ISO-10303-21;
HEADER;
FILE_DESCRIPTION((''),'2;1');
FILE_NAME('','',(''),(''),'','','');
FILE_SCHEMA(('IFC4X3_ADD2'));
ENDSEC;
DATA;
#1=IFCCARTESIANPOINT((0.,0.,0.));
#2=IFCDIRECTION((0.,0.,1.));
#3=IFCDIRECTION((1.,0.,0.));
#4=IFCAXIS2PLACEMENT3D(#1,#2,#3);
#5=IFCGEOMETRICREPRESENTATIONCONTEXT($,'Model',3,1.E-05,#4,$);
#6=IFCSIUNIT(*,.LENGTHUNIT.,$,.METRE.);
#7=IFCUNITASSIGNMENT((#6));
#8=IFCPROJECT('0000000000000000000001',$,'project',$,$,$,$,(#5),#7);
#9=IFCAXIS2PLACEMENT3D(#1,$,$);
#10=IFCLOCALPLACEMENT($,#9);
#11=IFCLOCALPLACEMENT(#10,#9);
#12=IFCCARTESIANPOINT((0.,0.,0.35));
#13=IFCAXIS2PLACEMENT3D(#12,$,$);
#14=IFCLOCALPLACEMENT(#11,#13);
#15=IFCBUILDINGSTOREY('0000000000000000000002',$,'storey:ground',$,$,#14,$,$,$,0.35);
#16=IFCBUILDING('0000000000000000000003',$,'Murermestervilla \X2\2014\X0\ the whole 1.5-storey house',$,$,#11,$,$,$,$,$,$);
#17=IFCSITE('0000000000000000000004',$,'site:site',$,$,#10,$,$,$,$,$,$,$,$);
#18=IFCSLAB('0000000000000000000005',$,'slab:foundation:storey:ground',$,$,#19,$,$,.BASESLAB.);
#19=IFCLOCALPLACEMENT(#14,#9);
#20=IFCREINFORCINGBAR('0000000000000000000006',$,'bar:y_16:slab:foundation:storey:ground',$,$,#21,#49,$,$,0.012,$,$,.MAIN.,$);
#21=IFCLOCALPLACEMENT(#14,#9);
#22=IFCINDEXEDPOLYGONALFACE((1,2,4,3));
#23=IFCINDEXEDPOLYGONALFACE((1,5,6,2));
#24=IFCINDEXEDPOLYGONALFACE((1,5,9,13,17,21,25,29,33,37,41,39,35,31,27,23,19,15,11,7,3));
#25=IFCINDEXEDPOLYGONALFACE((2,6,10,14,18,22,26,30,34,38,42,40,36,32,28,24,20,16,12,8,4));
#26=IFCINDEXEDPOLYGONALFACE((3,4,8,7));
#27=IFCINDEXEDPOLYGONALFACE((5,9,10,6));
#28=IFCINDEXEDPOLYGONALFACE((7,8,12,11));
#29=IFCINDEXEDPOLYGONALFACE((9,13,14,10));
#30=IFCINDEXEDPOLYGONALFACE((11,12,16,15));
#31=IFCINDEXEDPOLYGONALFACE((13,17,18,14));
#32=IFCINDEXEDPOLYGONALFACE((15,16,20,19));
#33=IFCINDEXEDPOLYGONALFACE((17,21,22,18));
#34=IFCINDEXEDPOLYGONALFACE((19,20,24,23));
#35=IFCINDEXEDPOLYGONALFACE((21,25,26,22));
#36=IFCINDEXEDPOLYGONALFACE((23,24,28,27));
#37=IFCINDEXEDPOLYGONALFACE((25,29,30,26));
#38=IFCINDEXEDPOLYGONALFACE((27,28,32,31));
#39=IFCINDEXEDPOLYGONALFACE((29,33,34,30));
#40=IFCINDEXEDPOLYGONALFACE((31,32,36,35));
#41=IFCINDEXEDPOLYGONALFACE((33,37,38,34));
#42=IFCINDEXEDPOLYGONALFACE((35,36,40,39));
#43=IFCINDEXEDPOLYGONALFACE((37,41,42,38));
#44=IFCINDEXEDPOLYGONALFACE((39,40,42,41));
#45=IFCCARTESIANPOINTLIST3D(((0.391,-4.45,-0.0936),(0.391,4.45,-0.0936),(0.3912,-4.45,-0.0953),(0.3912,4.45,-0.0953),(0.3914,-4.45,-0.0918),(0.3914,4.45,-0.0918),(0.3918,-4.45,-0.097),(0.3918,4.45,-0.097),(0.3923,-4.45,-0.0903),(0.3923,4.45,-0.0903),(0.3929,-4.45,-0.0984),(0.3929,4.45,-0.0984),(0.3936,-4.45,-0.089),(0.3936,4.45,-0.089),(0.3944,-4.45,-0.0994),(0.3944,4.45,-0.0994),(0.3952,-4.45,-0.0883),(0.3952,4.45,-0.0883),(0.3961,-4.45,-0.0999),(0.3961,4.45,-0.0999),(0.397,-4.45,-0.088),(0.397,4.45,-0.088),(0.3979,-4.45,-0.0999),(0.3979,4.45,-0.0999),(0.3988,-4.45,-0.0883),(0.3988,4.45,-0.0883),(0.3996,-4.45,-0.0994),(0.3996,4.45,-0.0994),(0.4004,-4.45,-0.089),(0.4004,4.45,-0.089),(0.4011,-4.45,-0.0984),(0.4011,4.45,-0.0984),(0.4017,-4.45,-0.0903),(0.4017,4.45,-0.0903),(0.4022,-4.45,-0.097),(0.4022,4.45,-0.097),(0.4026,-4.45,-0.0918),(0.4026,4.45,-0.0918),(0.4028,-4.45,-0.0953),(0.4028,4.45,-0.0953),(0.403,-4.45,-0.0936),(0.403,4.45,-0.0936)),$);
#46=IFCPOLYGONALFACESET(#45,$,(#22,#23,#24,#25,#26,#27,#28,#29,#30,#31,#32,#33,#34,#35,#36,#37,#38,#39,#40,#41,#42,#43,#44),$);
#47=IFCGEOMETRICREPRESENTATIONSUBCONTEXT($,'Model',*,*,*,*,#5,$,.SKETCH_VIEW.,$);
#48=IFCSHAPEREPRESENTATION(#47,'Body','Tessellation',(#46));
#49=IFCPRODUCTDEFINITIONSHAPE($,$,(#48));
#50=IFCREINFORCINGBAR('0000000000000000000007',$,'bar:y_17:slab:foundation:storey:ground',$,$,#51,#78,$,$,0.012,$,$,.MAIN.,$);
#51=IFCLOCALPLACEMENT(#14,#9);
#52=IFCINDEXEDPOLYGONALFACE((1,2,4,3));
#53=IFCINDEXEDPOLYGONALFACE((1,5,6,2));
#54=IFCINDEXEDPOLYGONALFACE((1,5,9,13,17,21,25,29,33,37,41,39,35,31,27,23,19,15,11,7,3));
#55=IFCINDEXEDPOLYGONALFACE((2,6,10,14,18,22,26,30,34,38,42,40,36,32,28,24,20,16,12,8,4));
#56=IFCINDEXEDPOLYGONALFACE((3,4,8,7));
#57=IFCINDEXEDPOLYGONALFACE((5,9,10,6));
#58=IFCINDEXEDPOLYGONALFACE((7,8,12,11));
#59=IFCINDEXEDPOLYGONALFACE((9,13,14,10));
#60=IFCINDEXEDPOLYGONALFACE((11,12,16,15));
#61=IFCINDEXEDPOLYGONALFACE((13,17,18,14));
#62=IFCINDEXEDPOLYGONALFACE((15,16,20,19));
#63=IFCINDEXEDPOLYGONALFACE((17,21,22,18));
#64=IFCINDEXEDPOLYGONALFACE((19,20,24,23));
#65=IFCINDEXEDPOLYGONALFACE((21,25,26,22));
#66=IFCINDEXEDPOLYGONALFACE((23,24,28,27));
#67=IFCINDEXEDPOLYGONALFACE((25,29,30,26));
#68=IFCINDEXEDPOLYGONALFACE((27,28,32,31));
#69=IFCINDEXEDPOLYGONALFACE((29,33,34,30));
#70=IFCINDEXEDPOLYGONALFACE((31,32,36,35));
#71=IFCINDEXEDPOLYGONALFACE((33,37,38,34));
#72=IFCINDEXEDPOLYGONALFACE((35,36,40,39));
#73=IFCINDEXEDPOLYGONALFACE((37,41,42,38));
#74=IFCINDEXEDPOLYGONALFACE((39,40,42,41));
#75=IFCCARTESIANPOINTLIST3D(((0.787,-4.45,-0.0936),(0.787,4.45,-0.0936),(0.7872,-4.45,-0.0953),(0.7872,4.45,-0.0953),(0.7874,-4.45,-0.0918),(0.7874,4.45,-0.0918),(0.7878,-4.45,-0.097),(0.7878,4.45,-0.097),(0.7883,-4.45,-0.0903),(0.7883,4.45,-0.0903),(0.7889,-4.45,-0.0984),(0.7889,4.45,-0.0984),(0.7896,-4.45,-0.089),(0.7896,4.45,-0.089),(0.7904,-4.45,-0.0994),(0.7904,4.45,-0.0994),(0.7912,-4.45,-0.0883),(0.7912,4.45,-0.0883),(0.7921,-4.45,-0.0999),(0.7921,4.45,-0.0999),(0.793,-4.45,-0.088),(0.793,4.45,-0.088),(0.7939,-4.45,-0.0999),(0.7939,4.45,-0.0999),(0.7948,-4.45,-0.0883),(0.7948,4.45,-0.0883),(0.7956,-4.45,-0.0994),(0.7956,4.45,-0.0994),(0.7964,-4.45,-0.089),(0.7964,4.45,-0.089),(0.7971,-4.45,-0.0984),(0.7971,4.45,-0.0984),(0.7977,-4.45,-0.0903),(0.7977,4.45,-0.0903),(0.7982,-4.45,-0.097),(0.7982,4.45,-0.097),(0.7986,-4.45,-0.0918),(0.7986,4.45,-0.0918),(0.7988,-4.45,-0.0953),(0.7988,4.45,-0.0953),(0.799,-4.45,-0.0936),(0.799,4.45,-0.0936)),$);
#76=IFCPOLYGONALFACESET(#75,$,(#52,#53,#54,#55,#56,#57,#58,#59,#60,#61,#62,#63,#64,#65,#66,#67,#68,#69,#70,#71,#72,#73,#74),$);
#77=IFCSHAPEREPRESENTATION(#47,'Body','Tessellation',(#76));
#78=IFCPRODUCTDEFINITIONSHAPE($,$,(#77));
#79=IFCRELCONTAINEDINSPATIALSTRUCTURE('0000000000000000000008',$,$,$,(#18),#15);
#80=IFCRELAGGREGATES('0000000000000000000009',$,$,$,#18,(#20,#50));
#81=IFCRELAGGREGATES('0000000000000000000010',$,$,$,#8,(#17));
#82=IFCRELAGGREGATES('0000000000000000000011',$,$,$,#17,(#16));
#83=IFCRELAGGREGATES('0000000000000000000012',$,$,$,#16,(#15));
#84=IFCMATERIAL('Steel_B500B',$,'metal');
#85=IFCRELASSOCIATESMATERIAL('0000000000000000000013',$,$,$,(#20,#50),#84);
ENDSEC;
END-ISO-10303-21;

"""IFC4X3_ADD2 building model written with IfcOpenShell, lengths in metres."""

from ifc_helpers import new_model, entity, si_unit, frame, origin, origin_with_axes, place, context, subcontext, project, spatial, material, element, aggregate, save


model = new_model("IFC4X3_ADD2")

# Units and contexts
model_context = context("Model", 3, precision=1e-05, world=origin_with_axes())
sub_context = subcontext(model_context, None, "Model", "SKETCH_VIEW")
ifc_project = project(units=[si_unit("LENGTHUNIT", "METRE")], contexts=[model_context])

# Site, building, storey
placement = place(None, origin())
site = spatial("IfcSite", under=ifc_project, at=placement, Name="site:site")
building_placement = place(placement, origin())
building = spatial("IfcBuilding", under=site, at=building_placement, Name="Murermestervilla — the whole 1.5-storey house")
storey_placement = place(building_placement, frame((0.0, 0.0, 0.35)))
storey = spatial("IfcBuildingStorey", under=building, at=storey_placement, Name="storey:ground", Elevation=0.35)

# Slab, reinforcing bars
slab_placement = place(storey_placement, frame((0.0, 0.0, -0.35)))
slab = element("IfcSlab", 1, at=slab_placement, inside=storey, Name="slab:foundation:storey:ground", PredefinedType="BASESLAB")
ifc_material = material(Name="Steel_B500B", Category="metal")
reinforcing_bar_1 = element("IfcReinforcingBar", 2, at=placement, material=ifc_material, Name="bar:y_16:slab:foundation:storey:ground", NominalDiameter=0.012, PredefinedType="MAIN", context=sub_context, shape_type="AdvancedSweptSolid", body=[
    entity("IfcSweptDiskSolid", entity("IfcPolyline", [entity("IfcCartesianPoint", [0.397, -4.45, 0.256]), entity("IfcCartesianPoint", [0.397, 4.45, 0.256])]), 0.006),
])
reinforcing_bar_2 = element("IfcReinforcingBar", 3, at=placement, material=ifc_material, Name="bar:y_17:slab:foundation:storey:ground", NominalDiameter=0.012, PredefinedType="MAIN", context=sub_context, shape_type="AdvancedSweptSolid", body=[
    entity("IfcSweptDiskSolid", entity("IfcPolyline", [entity("IfcCartesianPoint", [0.793, -4.45, 0.256]), entity("IfcCartesianPoint", [0.793, 4.45, 0.256])]), 0.006),
])
aggregate(slab, [reinforcing_bar_1, reinforcing_bar_2])

save(model, "model.ifc")
